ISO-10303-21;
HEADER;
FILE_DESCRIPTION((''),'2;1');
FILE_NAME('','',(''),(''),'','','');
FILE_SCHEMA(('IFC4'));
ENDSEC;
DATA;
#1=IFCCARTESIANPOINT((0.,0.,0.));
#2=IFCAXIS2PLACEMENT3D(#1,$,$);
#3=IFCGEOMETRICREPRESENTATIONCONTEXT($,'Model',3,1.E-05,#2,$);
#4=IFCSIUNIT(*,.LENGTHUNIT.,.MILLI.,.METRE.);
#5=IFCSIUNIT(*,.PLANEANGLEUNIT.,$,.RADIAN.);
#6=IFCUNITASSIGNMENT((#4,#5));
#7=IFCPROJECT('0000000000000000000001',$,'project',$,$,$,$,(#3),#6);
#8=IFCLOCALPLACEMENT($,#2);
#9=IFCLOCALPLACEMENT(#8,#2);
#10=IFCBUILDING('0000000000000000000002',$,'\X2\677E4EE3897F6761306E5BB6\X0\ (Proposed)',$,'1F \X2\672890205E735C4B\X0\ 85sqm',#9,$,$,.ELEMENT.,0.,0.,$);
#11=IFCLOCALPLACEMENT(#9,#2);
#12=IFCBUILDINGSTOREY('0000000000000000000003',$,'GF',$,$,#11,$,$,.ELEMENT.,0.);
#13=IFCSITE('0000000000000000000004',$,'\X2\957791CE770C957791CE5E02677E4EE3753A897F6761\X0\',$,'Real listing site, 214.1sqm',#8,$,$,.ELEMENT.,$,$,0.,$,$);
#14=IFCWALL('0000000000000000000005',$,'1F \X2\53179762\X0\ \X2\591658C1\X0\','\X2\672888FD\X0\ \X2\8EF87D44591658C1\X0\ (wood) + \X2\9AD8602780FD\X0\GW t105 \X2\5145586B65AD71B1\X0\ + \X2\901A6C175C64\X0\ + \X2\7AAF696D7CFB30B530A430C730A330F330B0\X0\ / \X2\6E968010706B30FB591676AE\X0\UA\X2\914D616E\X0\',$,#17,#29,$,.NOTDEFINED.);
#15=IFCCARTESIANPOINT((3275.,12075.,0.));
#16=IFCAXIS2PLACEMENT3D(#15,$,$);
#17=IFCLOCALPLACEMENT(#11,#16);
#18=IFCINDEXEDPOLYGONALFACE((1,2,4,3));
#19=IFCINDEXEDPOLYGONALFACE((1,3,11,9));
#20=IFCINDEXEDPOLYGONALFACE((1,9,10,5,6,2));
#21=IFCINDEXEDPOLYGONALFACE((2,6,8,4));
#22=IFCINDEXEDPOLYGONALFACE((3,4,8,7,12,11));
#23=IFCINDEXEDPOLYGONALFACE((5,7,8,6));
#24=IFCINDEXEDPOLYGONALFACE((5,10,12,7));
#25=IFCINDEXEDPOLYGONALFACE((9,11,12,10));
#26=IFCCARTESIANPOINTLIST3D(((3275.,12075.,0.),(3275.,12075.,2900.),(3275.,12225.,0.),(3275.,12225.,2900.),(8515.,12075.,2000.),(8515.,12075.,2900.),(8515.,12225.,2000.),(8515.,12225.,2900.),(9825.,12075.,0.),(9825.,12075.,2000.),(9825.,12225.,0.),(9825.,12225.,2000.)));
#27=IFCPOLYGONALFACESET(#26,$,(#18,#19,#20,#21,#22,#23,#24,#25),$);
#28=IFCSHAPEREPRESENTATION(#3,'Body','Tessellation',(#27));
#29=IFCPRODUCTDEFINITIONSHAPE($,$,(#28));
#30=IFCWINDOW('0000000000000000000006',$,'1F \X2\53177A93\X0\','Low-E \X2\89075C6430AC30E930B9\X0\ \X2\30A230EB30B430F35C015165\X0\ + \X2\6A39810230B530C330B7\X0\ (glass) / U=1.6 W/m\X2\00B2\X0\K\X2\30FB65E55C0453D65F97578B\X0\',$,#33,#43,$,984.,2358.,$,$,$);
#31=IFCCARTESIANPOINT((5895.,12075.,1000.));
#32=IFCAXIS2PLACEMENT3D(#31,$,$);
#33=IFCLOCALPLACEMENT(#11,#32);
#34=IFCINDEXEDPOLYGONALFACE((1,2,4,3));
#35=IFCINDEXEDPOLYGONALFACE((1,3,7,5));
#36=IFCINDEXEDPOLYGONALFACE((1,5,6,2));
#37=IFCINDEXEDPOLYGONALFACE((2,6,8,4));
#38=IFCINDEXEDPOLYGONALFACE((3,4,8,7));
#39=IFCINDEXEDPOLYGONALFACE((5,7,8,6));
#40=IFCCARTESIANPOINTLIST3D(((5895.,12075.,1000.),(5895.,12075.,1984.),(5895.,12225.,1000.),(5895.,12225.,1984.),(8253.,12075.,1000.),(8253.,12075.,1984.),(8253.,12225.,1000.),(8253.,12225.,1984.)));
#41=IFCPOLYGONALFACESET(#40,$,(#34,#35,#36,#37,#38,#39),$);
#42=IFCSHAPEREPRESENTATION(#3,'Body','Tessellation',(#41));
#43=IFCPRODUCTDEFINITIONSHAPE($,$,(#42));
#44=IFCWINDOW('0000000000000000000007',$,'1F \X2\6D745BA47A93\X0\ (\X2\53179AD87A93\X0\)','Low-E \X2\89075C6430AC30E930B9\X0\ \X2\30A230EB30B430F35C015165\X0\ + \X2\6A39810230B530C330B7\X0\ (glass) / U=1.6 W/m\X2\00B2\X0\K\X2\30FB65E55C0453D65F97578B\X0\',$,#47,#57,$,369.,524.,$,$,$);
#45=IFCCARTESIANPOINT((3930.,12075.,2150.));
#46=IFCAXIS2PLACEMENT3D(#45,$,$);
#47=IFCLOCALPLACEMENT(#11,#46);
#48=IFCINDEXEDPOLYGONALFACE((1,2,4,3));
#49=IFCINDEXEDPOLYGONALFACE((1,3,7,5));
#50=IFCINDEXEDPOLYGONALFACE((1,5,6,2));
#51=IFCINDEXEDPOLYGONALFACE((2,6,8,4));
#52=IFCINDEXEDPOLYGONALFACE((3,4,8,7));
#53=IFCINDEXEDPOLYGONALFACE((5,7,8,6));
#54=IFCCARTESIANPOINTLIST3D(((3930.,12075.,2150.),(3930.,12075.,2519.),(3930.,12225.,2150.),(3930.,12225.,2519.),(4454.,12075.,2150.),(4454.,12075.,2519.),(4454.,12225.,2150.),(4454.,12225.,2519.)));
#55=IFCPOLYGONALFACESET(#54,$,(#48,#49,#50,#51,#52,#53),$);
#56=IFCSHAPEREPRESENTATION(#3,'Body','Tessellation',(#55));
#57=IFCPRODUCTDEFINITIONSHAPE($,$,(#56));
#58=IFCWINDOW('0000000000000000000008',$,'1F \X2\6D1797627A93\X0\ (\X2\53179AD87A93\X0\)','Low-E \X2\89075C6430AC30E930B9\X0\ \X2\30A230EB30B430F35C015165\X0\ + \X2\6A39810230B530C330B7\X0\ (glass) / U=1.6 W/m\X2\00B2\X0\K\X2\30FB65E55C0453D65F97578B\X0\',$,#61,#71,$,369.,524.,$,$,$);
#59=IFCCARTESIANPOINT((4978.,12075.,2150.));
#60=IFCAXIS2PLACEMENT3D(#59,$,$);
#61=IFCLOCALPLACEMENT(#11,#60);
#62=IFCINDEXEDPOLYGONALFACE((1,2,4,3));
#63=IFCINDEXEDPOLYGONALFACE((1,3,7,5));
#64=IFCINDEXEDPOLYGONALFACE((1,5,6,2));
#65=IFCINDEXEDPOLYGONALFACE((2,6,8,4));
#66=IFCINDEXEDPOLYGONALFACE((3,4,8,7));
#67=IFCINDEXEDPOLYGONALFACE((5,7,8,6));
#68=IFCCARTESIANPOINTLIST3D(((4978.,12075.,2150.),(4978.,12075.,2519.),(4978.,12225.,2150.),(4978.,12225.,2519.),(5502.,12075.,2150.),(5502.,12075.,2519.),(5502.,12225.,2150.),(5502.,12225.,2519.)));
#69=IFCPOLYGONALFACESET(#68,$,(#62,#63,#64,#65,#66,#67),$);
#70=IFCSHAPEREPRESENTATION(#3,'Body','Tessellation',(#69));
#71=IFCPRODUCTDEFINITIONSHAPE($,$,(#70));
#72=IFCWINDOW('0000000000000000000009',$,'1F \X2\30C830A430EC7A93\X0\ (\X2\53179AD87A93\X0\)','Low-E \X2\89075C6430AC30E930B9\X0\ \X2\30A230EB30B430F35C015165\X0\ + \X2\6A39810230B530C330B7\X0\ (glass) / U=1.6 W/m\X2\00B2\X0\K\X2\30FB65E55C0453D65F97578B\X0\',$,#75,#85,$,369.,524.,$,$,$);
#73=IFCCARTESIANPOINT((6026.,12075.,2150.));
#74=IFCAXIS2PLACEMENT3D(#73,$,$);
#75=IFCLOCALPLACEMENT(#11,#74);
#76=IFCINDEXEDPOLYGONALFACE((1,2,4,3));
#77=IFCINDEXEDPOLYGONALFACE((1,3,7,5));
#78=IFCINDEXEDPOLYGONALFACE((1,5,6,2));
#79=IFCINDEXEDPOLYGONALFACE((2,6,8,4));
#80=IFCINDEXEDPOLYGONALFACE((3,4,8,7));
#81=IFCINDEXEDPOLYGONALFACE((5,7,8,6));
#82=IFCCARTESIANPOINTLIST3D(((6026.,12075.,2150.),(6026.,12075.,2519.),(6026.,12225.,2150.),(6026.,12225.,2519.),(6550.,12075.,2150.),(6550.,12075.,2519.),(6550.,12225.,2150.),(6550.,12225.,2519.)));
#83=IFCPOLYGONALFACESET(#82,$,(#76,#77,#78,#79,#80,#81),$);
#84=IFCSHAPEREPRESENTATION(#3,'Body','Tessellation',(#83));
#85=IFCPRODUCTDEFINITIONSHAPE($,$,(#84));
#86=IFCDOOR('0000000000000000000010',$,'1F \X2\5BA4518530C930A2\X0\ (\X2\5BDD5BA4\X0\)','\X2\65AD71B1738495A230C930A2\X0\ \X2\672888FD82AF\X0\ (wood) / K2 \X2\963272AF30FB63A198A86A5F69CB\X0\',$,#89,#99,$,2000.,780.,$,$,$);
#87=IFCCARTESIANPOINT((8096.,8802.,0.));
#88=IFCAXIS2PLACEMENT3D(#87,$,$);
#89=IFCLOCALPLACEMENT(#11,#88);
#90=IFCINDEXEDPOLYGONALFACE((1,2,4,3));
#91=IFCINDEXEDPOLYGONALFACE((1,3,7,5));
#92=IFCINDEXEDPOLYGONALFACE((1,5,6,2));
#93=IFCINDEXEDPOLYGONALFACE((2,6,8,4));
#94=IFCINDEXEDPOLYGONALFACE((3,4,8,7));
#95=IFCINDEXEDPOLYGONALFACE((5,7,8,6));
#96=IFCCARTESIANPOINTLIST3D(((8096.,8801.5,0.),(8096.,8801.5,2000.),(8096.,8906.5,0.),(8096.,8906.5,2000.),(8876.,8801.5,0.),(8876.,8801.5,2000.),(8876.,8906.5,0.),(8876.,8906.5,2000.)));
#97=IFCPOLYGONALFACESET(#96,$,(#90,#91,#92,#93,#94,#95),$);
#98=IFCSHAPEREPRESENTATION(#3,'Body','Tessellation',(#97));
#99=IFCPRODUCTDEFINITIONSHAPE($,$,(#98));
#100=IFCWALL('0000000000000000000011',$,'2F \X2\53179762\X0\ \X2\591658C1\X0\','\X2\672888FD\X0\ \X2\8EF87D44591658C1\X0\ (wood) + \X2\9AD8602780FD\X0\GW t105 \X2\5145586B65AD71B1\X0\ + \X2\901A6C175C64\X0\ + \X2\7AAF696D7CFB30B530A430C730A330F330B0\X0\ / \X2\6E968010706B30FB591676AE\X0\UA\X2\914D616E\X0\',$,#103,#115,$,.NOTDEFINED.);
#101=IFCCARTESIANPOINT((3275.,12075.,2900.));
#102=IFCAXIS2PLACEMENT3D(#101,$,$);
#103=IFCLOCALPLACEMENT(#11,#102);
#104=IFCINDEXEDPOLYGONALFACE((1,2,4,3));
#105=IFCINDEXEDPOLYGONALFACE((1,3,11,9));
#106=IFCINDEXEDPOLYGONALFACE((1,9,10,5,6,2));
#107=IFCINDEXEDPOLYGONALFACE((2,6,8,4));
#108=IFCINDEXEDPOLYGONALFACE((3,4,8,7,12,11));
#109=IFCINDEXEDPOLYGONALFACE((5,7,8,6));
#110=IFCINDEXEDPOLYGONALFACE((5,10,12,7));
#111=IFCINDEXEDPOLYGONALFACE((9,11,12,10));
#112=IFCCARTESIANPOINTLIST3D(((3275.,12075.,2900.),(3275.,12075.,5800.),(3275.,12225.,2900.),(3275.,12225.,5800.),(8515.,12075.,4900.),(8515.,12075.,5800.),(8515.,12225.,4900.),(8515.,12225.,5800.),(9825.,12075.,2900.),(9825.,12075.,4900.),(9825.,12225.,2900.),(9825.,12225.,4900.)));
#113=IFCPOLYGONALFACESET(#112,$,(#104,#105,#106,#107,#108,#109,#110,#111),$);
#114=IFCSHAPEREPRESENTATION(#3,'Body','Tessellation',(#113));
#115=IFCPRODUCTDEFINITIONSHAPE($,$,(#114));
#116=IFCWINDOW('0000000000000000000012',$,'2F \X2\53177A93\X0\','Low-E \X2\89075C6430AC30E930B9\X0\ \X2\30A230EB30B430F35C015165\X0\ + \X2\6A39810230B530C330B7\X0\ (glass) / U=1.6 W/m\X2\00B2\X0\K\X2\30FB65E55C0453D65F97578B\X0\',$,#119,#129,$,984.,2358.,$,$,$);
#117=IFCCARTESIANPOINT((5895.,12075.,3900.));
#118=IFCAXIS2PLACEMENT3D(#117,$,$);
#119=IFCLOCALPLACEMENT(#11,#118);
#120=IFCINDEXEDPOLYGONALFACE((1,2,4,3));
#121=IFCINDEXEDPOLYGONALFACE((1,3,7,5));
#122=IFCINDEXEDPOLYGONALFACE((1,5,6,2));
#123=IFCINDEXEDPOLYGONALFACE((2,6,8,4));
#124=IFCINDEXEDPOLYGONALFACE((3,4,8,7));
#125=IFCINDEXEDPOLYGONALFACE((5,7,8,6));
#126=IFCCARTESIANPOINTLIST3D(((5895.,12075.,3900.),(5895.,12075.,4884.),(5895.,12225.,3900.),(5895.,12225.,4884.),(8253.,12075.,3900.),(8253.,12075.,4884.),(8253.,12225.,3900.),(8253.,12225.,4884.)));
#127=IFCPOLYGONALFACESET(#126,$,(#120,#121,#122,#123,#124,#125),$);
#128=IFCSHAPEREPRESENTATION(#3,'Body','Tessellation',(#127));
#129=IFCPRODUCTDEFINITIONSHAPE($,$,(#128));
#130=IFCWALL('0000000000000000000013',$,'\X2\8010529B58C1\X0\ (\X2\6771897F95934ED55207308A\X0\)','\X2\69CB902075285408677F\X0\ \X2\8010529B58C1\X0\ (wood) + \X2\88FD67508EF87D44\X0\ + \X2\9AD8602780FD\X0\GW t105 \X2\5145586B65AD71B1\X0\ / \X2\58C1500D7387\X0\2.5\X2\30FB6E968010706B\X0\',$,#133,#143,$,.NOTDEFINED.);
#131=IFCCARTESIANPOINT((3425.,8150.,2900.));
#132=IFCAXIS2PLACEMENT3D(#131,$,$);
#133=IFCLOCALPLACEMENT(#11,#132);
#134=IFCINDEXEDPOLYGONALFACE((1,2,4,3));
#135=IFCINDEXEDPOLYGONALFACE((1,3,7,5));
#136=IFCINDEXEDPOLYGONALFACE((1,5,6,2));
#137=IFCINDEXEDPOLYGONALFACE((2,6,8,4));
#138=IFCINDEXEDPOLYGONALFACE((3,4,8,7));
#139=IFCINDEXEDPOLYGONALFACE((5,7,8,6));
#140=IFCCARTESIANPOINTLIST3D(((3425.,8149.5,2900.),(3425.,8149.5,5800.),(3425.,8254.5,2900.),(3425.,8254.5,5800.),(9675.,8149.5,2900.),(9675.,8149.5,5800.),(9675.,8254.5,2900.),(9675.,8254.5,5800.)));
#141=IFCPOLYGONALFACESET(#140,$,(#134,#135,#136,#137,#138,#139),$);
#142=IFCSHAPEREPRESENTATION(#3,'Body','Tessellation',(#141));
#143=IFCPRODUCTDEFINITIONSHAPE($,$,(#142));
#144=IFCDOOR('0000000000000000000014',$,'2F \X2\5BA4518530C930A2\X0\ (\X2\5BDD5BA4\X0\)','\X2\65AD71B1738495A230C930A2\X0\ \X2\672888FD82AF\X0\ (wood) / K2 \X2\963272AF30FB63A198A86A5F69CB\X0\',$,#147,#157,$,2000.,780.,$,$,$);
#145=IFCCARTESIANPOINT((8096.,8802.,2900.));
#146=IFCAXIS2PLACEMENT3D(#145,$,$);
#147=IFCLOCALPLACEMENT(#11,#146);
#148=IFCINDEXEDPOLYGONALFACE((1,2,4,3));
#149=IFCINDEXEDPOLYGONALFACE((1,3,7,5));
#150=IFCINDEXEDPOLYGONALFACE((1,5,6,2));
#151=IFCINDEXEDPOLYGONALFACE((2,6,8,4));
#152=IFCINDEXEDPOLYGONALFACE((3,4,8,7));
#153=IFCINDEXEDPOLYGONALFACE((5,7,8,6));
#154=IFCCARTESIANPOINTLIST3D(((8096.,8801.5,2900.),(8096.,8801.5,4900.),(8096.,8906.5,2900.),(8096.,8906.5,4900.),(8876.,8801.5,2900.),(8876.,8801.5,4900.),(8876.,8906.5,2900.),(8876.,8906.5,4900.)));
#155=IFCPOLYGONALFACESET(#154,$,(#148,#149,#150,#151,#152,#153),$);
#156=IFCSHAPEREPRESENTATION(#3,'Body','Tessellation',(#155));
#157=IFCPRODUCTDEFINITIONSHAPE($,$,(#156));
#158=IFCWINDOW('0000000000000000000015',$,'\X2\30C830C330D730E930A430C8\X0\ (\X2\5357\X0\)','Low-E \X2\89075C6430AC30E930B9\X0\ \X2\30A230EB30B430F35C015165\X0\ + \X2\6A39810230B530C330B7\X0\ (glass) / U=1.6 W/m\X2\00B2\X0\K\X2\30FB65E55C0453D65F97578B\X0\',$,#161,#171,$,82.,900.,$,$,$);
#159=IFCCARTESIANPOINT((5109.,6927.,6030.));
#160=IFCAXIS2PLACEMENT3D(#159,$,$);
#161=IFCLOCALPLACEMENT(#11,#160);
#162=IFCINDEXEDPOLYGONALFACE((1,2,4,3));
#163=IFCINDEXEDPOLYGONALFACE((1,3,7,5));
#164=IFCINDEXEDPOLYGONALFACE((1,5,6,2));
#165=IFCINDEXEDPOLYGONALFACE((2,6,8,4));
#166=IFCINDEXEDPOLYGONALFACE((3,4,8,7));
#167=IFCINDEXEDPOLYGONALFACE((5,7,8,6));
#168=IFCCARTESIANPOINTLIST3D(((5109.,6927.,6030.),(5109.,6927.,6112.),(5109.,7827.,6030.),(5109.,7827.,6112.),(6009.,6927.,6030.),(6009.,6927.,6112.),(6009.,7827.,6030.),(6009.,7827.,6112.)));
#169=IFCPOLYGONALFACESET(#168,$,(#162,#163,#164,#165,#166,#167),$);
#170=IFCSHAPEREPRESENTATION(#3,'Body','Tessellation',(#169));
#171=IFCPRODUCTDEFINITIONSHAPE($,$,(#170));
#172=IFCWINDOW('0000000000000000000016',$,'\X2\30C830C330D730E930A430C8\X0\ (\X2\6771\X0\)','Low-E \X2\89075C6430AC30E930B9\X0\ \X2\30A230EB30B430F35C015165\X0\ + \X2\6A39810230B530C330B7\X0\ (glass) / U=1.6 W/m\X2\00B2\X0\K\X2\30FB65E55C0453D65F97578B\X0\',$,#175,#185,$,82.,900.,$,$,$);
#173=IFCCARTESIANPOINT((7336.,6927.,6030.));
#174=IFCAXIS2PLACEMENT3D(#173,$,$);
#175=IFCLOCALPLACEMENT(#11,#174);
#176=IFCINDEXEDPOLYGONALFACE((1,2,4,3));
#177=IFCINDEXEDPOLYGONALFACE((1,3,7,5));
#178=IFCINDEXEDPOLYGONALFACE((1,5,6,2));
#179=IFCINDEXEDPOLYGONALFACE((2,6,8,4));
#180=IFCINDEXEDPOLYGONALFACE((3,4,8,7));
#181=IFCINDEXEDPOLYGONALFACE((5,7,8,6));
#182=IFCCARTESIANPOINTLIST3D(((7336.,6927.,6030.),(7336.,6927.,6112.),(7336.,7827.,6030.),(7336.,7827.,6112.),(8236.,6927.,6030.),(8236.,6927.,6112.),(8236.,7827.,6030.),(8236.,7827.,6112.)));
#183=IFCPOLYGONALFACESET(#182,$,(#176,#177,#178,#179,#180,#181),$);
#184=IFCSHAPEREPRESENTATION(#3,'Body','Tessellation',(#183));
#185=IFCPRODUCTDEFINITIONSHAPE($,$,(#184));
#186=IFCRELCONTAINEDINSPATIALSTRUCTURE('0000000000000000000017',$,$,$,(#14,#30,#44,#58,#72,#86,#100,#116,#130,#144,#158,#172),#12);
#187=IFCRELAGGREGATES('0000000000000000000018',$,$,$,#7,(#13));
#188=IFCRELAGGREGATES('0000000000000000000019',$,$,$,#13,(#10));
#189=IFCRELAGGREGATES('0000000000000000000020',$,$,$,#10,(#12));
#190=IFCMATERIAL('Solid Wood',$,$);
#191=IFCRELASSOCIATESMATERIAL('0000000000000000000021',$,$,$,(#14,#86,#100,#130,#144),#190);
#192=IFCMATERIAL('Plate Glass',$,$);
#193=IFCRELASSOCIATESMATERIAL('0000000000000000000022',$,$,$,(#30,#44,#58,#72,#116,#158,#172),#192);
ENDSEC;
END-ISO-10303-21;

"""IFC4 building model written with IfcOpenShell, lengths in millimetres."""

from ifc_helpers import new_model, si_unit, frame, frame_2d, origin, place, context, project, spatial, rectangle, extrude, material, element, fill, save


model = new_model("IFC4")

# Units and contexts
model_context = context("Model", 3, precision=1e-05, world=origin())
ifc_project = project(units=[si_unit("LENGTHUNIT", "METRE", prefix="MILLI"), si_unit("PLANEANGLEUNIT", "RADIAN")], contexts=[model_context])

# Site, building, storey
site_placement = place(None, origin())
site = spatial("IfcSite", under=ifc_project, at=site_placement, Name="長野県長野市松代町西条", ObjectType="Real listing site, 214.1sqm", CompositionType="ELEMENT", RefElevation=0.0)
building_placement = place(site_placement, origin())
building = spatial("IfcBuilding", under=site, at=building_placement, Name="松代西条の家 (Proposed)", ObjectType="1F 木造平屋 85sqm", CompositionType="ELEMENT", ElevationOfRefHeight=0.0, ElevationOfTerrain=0.0)
storey_placement = place(building_placement, origin())
storey = spatial("IfcBuildingStorey", under=building, at=storey_placement, Name="GF", CompositionType="ELEMENT", Elevation=0.0)

# Wall, openings, windows
ifc_material_1 = material(Name="Solid Wood")
wall_1_placement = place(storey_placement, frame((3275.0, 12075.0, 0.0)))
wall_1 = element("IfcWall", 1, at=wall_1_placement, inside=storey, material=ifc_material_1, Name="1F 北面 外壁", Description="木製 軸組外壁 (wood) + 高性能GW t105 充填断熱 + 通気層 + 窯業系サイディング / 準耐火・外皮UA配慮", PredefinedType="NOTDEFINED", context=model_context, shape_type="SweptSolid", body=[
    extrude(rectangle(XDim=6550.0, YDim=150.0, at=frame_2d((3275.0, 75.0))), frame((3275.0, 12075.0, 0.0)), (0.0, 0.0, 1.0), 2900.0),
])
opening_1_placement = place(storey_placement, frame((5895.0, 12075.0, 1000.0)))
opening_1 = element("IfcOpeningElement", 2, at=opening_1_placement, cuts=wall_1, PredefinedType="NOTDEFINED", context=model_context, shape_type="SweptSolid", body=[
    extrude(rectangle(XDim=2358.0, YDim=150.0, at=frame_2d((1179.0, 75.0))), frame((5895.0, 12075.0, 1000.0)), (0.0, 0.0, 1.0), 984.0),
])
opening_2_placement = place(storey_placement, frame((3930.0, 12075.0, 2150.0)))
opening_2 = element("IfcOpeningElement", 3, at=opening_2_placement, cuts=wall_1, PredefinedType="NOTDEFINED", context=model_context, shape_type="SweptSolid", body=[
    extrude(rectangle(XDim=524.0, YDim=150.0, at=frame_2d((262.0, 75.0))), frame((3930.0, 12075.0, 2150.0)), (0.0, 0.0, 1.0), 369.0),
])
opening_3_placement = place(storey_placement, frame((4978.0, 12075.0, 2150.0)))
opening_3 = element("IfcOpeningElement", 4, at=opening_3_placement, cuts=wall_1, PredefinedType="NOTDEFINED", context=model_context, shape_type="SweptSolid", body=[
    extrude(rectangle(XDim=524.0, YDim=150.0, at=frame_2d((262.0, 75.0))), frame((4978.0, 12075.0, 2150.0)), (0.0, 0.0, 1.0), 369.0),
])
opening_4_placement = place(storey_placement, frame((6026.0, 12075.0, 2150.0)))
opening_4 = element("IfcOpeningElement", 5, at=opening_4_placement, cuts=wall_1, PredefinedType="NOTDEFINED", context=model_context, shape_type="SweptSolid", body=[
    extrude(rectangle(XDim=524.0, YDim=150.0, at=frame_2d((262.0, 75.0))), frame((6026.0, 12075.0, 2150.0)), (0.0, 0.0, 1.0), 369.0),
])
ifc_material_2 = material(Name="Plate Glass")
window_1_placement = place(storey_placement, frame((5895.0, 12075.0, 1000.0)))
window_1 = element("IfcWindow", 6, at=window_1_placement, inside=storey, material=ifc_material_2, Name="1F 北窓", Description="Low-E 複層ガラス アルゴン封入 + 樹脂サッシ (glass) / U=1.6 W/m²K・日射取得型", OverallHeight=984.0, OverallWidth=2358.0, context=model_context, shape_type="SweptSolid", body=[
    extrude(rectangle(XDim=2358.0, YDim=150.0, at=frame_2d((1179.0, 75.0))), frame((5895.0, 12075.0, 1000.0)), (0.0, 0.0, 1.0), 984.0),
])
fill(opening_1, window_1)
window_2_placement = place(storey_placement, frame((3930.0, 12075.0, 2150.0)))
window_2 = element("IfcWindow", 7, at=window_2_placement, inside=storey, material=ifc_material_2, Name="1F 浴室窓 (北高窓)", Description="Low-E 複層ガラス アルゴン封入 + 樹脂サッシ (glass) / U=1.6 W/m²K・日射取得型", OverallHeight=369.0, OverallWidth=524.0, context=model_context, shape_type="SweptSolid", body=[
    extrude(rectangle(XDim=524.0, YDim=150.0, at=frame_2d((262.0, 75.0))), frame((3930.0, 12075.0, 2150.0)), (0.0, 0.0, 1.0), 369.0),
])
fill(opening_2, window_2)
window_3_placement = place(storey_placement, frame((4978.0, 12075.0, 2150.0)))
window_3 = element("IfcWindow", 8, at=window_3_placement, inside=storey, material=ifc_material_2, Name="1F 洗面窓 (北高窓)", Description="Low-E 複層ガラス アルゴン封入 + 樹脂サッシ (glass) / U=1.6 W/m²K・日射取得型", OverallHeight=369.0, OverallWidth=524.0, context=model_context, shape_type="SweptSolid", body=[
    extrude(rectangle(XDim=524.0, YDim=150.0, at=frame_2d((262.0, 75.0))), frame((4978.0, 12075.0, 2150.0)), (0.0, 0.0, 1.0), 369.0),
])
fill(opening_3, window_3)
window_4_placement = place(storey_placement, frame((6026.0, 12075.0, 2150.0)))
window_4 = element("IfcWindow", 9, at=window_4_placement, inside=storey, material=ifc_material_2, Name="1F トイレ窓 (北高窓)", Description="Low-E 複層ガラス アルゴン封入 + 樹脂サッシ (glass) / U=1.6 W/m²K・日射取得型", OverallHeight=369.0, OverallWidth=524.0, context=model_context, shape_type="SweptSolid", body=[
    extrude(rectangle(XDim=524.0, YDim=150.0, at=frame_2d((262.0, 75.0))), frame((6026.0, 12075.0, 2150.0)), (0.0, 0.0, 1.0), 369.0),
])
fill(opening_4, window_4)

# Door
door_1_placement = place(storey_placement, frame((8096.0, 8802.0, 0.0)))
element("IfcDoor", 10, at=door_1_placement, inside=storey, material=ifc_material_1, Name="1F 室内ドア (寝室)", Description="断熱玄関ドア 木製芯 (wood) / K2 防犯・採風機構", OverallHeight=2000.0, OverallWidth=780.0, context=model_context, shape_type="SweptSolid", body=[
    extrude(rectangle(XDim=780.0, YDim=105.0, at=frame_2d((390.0, 52.0))), frame((8096.0, 8802.0, 0.0)), (0.0, 0.0, 1.0), 2000.0),
])

# Wall, opening, window
wall_2_placement = place(storey_placement, frame((3275.0, 12075.0, 2900.0)))
wall_2 = element("IfcWall", 11, at=wall_2_placement, inside=storey, material=ifc_material_1, Name="2F 北面 外壁", Description="木製 軸組外壁 (wood) + 高性能GW t105 充填断熱 + 通気層 + 窯業系サイディング / 準耐火・外皮UA配慮", PredefinedType="NOTDEFINED", context=model_context, shape_type="SweptSolid", body=[
    extrude(rectangle(XDim=6550.0, YDim=150.0, at=frame_2d((3275.0, 75.0))), frame((3275.0, 12075.0, 2900.0)), (0.0, 0.0, 1.0), 2900.0),
])
opening_5_placement = place(storey_placement, frame((5895.0, 12075.0, 3900.0)))
opening_5 = element("IfcOpeningElement", 12, at=opening_5_placement, cuts=wall_2, PredefinedType="NOTDEFINED", context=model_context, shape_type="SweptSolid", body=[
    extrude(rectangle(XDim=2358.0, YDim=150.0, at=frame_2d((1179.0, 75.0))), frame((5895.0, 12075.0, 3900.0)), (0.0, 0.0, 1.0), 984.0),
])
window_5_placement = place(storey_placement, frame((5895.0, 12075.0, 3900.0)))
window_5 = element("IfcWindow", 13, at=window_5_placement, inside=storey, material=ifc_material_2, Name="2F 北窓", Description="Low-E 複層ガラス アルゴン封入 + 樹脂サッシ (glass) / U=1.6 W/m²K・日射取得型", OverallHeight=984.0, OverallWidth=2358.0, context=model_context, shape_type="SweptSolid", body=[
    extrude(rectangle(XDim=2358.0, YDim=150.0, at=frame_2d((1179.0, 75.0))), frame((5895.0, 12075.0, 3900.0)), (0.0, 0.0, 1.0), 984.0),
])
fill(opening_5, window_5)

# Wall
wall_3_placement = place(storey_placement, frame((3425.0, 8150.0, 2900.0)))
element("IfcWall", 14, at=wall_3_placement, inside=storey, material=ifc_material_1, Name="耐力壁 (東西間仕切り)", Description="構造用合板 耐力壁 (wood) + 製材軸組 + 高性能GW t105 充填断熱 / 壁倍率2.5・準耐火", PredefinedType="NOTDEFINED", context=model_context, shape_type="SweptSolid", body=[
    extrude(rectangle(XDim=6250.0, YDim=105.0, at=frame_2d((3125.0, 52.0))), frame((3425.0, 8150.0, 2900.0)), (0.0, 0.0, 1.0), 2900.0),
])

# Door
door_2_placement = place(storey_placement, frame((8096.0, 8802.0, 2900.0)))
element("IfcDoor", 15, at=door_2_placement, inside=storey, material=ifc_material_1, Name="2F 室内ドア (寝室)", Description="断熱玄関ドア 木製芯 (wood) / K2 防犯・採風機構", OverallHeight=2000.0, OverallWidth=780.0, context=model_context, shape_type="SweptSolid", body=[
    extrude(rectangle(XDim=780.0, YDim=105.0, at=frame_2d((390.0, 52.0))), frame((8096.0, 8802.0, 2900.0)), (0.0, 0.0, 1.0), 2000.0),
])

# Windows
window_6_placement = place(storey_placement, frame((5109.0, 6927.0, 6030.0)))
element("IfcWindow", 16, at=window_6_placement, inside=storey, material=ifc_material_2, Name="トップライト (南)", Description="Low-E 複層ガラス アルゴン封入 + 樹脂サッシ (glass) / U=1.6 W/m²K・日射取得型", OverallHeight=82.0, OverallWidth=900.0, context=model_context, shape_type="SweptSolid", body=[
    extrude(rectangle(XDim=900.0, YDim=900.0, at=frame_2d((450.0, 450.0))), frame((5109.0, 6927.0, 6030.0)), (0.0, 0.0, 1.0), 82.0),
])
window_7_placement = place(storey_placement, frame((7336.0, 6927.0, 6030.0)))
element("IfcWindow", 17, at=window_7_placement, inside=storey, material=ifc_material_2, Name="トップライト (東)", Description="Low-E 複層ガラス アルゴン封入 + 樹脂サッシ (glass) / U=1.6 W/m²K・日射取得型", OverallHeight=82.0, OverallWidth=900.0, context=model_context, shape_type="SweptSolid", body=[
    extrude(rectangle(XDim=900.0, YDim=900.0, at=frame_2d((450.0, 450.0))), frame((7336.0, 6927.0, 6030.0)), (0.0, 0.0, 1.0), 82.0),
])

save(model, "model.ifc")
